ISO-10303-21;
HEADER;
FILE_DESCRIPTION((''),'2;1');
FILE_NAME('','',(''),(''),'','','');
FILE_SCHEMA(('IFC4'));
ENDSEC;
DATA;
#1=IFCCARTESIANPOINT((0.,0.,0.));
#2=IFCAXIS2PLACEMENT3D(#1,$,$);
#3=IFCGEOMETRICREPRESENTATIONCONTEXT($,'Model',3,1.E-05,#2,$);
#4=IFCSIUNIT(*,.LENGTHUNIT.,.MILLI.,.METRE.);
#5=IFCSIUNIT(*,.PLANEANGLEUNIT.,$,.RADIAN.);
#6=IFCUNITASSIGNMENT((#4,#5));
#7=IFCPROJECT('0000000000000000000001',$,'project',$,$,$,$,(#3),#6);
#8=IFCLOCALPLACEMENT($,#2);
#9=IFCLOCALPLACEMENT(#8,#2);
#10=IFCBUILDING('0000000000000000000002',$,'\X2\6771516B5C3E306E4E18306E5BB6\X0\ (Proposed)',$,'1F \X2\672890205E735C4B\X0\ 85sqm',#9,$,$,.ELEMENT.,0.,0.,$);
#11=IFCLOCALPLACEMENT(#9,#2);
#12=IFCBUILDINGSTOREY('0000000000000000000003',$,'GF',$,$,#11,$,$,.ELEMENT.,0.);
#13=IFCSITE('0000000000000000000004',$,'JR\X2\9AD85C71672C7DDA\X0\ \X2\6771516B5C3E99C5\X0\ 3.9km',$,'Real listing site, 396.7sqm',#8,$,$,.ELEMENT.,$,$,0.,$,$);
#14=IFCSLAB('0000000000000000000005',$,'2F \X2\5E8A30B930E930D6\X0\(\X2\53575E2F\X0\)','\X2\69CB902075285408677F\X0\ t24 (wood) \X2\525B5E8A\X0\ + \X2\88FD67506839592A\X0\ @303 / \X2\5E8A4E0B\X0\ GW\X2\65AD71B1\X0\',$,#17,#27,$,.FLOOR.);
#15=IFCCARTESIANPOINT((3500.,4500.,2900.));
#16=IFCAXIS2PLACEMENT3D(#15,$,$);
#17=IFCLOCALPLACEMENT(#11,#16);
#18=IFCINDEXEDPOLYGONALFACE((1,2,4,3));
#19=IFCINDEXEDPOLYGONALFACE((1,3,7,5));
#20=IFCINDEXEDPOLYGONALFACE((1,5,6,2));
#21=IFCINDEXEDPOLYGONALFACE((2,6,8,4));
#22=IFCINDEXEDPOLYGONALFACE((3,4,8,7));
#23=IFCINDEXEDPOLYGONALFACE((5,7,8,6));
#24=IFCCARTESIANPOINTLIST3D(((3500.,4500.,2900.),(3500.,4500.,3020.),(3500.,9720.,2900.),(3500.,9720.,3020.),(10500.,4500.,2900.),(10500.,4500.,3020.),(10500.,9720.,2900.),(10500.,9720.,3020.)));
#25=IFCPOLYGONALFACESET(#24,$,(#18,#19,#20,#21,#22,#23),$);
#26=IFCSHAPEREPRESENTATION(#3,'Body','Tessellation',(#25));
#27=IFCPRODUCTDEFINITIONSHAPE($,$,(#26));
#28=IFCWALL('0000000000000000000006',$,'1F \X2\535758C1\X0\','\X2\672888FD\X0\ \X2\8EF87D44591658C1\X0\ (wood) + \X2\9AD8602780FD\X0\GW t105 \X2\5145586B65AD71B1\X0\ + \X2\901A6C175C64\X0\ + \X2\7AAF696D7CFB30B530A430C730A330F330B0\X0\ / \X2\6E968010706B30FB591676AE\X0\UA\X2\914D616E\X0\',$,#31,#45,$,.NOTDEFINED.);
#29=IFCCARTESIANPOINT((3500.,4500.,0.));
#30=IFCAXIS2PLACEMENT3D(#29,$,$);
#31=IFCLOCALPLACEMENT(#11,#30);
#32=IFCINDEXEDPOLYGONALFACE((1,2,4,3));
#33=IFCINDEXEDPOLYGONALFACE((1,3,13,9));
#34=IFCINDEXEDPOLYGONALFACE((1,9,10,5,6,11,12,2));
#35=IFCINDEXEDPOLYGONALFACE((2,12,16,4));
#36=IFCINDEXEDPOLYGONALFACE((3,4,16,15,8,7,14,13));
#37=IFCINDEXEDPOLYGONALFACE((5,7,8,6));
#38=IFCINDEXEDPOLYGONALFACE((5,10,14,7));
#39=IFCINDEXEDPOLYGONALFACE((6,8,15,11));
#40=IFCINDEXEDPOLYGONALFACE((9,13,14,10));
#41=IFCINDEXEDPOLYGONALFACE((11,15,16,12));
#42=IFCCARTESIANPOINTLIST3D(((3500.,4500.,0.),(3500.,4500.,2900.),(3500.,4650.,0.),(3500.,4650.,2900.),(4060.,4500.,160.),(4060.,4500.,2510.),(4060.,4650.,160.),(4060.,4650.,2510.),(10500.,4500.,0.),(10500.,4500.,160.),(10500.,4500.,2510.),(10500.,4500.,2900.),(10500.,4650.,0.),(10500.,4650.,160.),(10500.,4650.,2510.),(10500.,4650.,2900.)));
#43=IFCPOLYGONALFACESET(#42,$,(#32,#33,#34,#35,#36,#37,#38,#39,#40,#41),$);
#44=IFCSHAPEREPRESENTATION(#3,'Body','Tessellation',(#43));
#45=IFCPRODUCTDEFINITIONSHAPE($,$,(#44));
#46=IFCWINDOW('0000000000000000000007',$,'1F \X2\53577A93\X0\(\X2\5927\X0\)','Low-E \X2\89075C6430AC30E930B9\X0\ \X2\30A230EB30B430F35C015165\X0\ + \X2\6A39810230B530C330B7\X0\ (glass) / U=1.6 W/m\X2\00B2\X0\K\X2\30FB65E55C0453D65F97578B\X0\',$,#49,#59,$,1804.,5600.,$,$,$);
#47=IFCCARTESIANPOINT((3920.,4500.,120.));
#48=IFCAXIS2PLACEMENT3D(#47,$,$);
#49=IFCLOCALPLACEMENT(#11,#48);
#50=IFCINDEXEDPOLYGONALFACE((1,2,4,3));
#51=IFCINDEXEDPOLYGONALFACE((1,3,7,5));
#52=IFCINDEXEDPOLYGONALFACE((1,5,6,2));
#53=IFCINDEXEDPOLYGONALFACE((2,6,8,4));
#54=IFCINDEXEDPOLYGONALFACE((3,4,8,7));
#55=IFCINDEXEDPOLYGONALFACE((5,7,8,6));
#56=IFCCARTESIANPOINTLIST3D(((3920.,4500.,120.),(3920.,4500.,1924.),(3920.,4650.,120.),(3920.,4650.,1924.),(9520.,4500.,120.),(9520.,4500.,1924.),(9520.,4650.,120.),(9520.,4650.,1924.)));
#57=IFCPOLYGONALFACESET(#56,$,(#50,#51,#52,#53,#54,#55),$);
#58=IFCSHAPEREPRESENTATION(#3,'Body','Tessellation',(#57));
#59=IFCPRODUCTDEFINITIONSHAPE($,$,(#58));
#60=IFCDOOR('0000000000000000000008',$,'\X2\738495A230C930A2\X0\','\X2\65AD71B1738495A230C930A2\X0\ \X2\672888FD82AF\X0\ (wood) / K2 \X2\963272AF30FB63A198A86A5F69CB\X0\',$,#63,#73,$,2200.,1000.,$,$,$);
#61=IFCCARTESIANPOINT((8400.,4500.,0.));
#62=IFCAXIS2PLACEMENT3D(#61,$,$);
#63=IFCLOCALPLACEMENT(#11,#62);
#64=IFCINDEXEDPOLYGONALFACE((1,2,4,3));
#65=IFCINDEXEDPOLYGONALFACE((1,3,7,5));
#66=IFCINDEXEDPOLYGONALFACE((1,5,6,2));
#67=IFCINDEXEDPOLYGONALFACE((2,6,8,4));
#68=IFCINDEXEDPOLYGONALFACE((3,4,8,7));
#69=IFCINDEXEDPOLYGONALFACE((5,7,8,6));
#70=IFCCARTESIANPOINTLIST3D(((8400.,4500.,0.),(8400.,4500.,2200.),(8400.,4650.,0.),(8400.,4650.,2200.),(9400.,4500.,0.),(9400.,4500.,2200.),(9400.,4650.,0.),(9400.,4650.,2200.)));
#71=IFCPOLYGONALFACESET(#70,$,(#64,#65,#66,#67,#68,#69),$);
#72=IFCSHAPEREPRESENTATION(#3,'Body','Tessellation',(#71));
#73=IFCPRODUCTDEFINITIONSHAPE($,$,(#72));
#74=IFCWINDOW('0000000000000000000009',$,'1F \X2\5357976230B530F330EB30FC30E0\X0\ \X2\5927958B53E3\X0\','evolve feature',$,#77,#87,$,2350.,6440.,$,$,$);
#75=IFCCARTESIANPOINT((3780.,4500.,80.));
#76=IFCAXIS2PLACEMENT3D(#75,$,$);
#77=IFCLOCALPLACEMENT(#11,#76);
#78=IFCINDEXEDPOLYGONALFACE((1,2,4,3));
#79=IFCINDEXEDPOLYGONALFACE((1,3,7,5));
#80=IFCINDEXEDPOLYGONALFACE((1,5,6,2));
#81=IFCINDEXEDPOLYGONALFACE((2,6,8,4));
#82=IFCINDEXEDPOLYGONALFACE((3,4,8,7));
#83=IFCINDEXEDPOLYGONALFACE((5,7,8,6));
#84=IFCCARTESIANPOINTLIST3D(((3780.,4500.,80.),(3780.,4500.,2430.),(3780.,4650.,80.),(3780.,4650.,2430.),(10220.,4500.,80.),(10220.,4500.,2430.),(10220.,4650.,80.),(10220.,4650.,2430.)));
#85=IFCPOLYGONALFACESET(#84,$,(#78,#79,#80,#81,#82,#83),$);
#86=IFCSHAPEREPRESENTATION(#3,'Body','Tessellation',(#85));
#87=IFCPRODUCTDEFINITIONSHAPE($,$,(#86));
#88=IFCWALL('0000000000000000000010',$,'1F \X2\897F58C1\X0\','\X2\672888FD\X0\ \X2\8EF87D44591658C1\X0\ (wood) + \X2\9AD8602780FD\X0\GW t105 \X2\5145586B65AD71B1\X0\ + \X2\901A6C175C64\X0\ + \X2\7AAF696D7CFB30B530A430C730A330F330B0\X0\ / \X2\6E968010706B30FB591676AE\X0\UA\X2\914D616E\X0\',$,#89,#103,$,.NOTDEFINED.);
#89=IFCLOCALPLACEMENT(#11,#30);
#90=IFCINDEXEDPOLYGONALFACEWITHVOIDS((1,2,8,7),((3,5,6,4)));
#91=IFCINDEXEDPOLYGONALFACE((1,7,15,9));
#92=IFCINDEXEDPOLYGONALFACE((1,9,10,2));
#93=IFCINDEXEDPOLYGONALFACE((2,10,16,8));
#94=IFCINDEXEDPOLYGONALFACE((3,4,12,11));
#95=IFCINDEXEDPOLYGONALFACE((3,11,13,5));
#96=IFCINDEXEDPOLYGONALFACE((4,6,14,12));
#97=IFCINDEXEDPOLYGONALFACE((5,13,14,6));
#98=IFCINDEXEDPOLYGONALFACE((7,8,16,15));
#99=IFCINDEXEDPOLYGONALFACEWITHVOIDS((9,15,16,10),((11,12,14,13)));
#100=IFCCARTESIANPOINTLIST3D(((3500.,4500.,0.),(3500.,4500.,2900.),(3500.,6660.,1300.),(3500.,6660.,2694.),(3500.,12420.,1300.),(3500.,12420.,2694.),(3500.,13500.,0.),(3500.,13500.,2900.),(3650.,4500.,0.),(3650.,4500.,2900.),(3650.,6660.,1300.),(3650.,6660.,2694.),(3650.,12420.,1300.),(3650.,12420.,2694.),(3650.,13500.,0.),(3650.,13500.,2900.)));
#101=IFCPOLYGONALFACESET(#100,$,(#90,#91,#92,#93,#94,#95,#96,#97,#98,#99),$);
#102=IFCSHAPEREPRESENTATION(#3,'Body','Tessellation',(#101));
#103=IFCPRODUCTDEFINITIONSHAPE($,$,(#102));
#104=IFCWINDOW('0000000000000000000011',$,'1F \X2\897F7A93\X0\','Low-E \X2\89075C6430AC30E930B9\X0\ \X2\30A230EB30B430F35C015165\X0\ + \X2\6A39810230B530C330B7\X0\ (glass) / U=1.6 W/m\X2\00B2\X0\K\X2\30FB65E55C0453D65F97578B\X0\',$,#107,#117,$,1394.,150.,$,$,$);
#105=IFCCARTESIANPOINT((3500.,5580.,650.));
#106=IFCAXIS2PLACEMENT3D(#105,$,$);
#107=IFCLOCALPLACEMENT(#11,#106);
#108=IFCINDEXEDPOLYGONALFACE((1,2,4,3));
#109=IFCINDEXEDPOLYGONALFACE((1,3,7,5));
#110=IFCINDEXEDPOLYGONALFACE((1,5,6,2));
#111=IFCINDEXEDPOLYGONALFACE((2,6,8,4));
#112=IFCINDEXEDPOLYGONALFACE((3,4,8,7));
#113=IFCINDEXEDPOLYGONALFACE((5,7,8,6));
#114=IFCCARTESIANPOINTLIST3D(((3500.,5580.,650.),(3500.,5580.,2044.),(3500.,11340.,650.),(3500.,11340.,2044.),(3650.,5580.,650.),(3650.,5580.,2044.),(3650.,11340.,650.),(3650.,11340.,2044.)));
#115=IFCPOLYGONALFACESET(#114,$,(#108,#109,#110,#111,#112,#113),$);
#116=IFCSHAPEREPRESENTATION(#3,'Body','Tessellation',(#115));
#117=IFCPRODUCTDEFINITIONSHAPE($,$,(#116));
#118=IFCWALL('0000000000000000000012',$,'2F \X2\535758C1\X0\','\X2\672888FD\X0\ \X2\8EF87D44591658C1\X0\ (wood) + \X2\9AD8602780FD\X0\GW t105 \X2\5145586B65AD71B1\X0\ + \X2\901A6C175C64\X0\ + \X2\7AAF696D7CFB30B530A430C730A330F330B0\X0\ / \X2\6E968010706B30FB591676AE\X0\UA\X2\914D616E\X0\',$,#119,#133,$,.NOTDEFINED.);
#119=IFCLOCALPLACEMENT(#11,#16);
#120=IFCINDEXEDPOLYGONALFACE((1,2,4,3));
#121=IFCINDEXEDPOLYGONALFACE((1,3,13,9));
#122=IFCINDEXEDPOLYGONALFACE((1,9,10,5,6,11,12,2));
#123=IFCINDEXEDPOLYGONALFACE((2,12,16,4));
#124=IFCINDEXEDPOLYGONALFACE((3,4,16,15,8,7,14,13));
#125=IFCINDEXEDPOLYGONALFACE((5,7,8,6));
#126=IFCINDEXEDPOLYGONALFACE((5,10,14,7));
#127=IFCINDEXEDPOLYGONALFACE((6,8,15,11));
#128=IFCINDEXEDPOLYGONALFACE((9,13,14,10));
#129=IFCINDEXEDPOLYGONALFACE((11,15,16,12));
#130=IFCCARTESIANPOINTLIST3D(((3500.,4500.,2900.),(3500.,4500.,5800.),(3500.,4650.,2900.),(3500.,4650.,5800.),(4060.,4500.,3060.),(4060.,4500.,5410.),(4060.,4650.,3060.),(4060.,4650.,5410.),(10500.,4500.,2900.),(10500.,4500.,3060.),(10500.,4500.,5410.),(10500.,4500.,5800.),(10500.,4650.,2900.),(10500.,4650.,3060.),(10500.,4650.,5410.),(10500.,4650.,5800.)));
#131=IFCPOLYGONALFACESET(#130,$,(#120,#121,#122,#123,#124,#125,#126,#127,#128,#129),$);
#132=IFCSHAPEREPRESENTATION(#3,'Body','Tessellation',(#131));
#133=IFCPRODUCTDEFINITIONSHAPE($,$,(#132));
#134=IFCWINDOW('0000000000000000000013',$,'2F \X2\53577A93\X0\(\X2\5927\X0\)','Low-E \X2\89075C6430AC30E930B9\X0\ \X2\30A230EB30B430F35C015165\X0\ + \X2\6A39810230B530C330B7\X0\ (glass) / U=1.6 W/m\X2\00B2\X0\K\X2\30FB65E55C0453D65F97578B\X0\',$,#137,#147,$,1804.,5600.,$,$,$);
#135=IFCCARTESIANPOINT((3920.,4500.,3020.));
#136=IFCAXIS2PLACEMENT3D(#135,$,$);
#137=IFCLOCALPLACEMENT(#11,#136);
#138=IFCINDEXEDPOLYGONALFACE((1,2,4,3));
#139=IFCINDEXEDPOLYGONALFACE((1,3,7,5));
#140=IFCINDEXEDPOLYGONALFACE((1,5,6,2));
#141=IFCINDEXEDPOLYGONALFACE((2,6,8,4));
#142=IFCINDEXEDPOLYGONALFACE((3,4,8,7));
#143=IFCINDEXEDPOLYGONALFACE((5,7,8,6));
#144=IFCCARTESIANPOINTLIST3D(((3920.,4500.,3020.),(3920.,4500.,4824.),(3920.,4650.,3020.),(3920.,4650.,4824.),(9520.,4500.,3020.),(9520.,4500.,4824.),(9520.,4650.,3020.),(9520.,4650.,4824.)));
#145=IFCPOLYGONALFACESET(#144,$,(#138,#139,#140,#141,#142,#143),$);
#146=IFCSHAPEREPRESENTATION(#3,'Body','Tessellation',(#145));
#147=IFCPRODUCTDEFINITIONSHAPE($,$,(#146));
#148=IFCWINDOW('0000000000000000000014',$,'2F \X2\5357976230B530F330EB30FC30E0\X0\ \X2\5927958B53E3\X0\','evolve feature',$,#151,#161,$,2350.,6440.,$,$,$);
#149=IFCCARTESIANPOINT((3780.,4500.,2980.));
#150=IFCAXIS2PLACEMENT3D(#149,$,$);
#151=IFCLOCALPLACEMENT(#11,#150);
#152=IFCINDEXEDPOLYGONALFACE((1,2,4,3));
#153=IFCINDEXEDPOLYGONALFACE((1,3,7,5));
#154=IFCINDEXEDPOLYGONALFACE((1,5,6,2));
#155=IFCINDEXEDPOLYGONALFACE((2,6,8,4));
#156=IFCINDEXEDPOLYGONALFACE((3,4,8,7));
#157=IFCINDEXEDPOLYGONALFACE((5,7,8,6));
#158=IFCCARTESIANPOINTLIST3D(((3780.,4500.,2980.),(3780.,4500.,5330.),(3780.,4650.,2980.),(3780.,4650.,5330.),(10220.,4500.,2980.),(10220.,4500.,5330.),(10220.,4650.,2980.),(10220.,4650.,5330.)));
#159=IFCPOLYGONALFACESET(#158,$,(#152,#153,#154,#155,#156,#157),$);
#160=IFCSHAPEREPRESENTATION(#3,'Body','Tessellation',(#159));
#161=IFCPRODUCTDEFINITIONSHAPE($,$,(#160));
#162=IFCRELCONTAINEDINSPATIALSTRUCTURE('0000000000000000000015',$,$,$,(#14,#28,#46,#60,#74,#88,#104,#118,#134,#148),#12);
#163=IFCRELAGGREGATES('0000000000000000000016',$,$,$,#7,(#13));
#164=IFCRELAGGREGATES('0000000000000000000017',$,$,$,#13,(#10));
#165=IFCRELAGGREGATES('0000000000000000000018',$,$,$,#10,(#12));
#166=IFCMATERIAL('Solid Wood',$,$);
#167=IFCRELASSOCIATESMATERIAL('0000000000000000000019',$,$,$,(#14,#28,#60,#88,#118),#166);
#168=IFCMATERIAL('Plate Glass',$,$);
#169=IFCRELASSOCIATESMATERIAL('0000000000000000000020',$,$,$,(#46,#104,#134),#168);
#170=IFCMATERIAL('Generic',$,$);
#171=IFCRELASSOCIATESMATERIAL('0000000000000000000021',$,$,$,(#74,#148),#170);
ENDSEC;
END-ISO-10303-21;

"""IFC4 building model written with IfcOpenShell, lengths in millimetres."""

from ifc_helpers import new_model, si_unit, frame, frame_2d, origin, place, context, project, spatial, rectangle, extrude, material, element, fill, save


model = new_model("IFC4")

# Units and contexts
model_context = context("Model", 3, precision=1e-05, world=origin())
ifc_project = project(units=[si_unit("LENGTHUNIT", "METRE", prefix="MILLI"), si_unit("PLANEANGLEUNIT", "RADIAN")], contexts=[model_context])

# Site, building, storey
site_placement = place(None, origin())
site = spatial("IfcSite", under=ifc_project, at=site_placement, Name="JR高山本線 東八尾駅 3.9km", ObjectType="Real listing site, 396.7sqm", CompositionType="ELEMENT", RefElevation=0.0)
building_placement = place(site_placement, origin())
building = spatial("IfcBuilding", under=site, at=building_placement, Name="東八尾の丘の家 (Proposed)", ObjectType="1F 木造平屋 85sqm", CompositionType="ELEMENT", ElevationOfRefHeight=0.0, ElevationOfTerrain=0.0)
storey_placement = place(building_placement, origin())
storey = spatial("IfcBuildingStorey", under=building, at=storey_placement, Name="GF", CompositionType="ELEMENT", Elevation=0.0)

# Slab
ifc_material_1 = material(Name="Solid Wood")
slab_1_placement = place(storey_placement, frame((3500.0, 4500.0, 2900.0)))
element("IfcSlab", 1, at=slab_1_placement, inside=storey, material=ifc_material_1, Name="2F 床スラブ(南帯)", Description="構造用合板 t24 (wood) 剛床 + 製材根太 @303 / 床下 GW断熱", PredefinedType="FLOOR", context=model_context, shape_type="SweptSolid", body=[
    extrude(rectangle(XDim=7000.0, YDim=5220.0, at=frame_2d((3500.0, 2610.0))), frame((3500.0, 4500.0, 2900.0)), (0.0, 0.0, 1.0), 120.0),
])
ifc_material_2 = material(Name="Generic")

# Wall, openings, windows, door
wall_1_placement = place(storey_placement, frame((3500.0, 4500.0, 0.0)))
wall_1 = element("IfcWall", 2, at=wall_1_placement, inside=storey, material=ifc_material_1, Name="1F 南壁", Description="木製 軸組外壁 (wood) + 高性能GW t105 充填断熱 + 通気層 + 窯業系サイディング / 準耐火・外皮UA配慮", PredefinedType="NOTDEFINED", context=model_context, shape_type="SweptSolid", body=[
    extrude(rectangle(XDim=7000.0, YDim=150.0, at=frame_2d((3500.0, 75.0))), frame((3500.0, 4500.0, 0.0)), (0.0, 0.0, 1.0), 2900.0),
])
opening_1_placement = place(storey_placement, frame((3920.0, 4500.0, 120.0)))
opening_1 = element("IfcOpeningElement", 3, at=opening_1_placement, cuts=wall_1, PredefinedType="NOTDEFINED", context=model_context, shape_type="SweptSolid", body=[
    extrude(rectangle(XDim=5600.0, YDim=150.0, at=frame_2d((2800.0, 75.0))), frame((3920.0, 4500.0, 120.0)), (0.0, 0.0, 1.0), 1804.0),
])
opening_2_placement = place(storey_placement, frame((8400.0, 4500.0, 0.0)))
opening_2 = element("IfcOpeningElement", 4, at=opening_2_placement, cuts=wall_1, PredefinedType="NOTDEFINED", context=model_context, shape_type="SweptSolid", body=[
    extrude(rectangle(XDim=1000.0, YDim=150.0, at=frame_2d((500.0, 75.0))), frame((8400.0, 4500.0, 0.0)), (0.0, 0.0, 1.0), 2200.0),
])
opening_3_placement = place(storey_placement, frame((3780.0, 4500.0, 80.0)))
opening_3 = element("IfcOpeningElement", 5, at=opening_3_placement, cuts=wall_1, PredefinedType="NOTDEFINED", context=model_context, shape_type="SweptSolid", body=[
    extrude(rectangle(XDim=6440.0, YDim=150.0, at=frame_2d((3220.0, 75.0))), frame((3780.0, 4500.0, 80.0)), (0.0, 0.0, 1.0), 2350.0),
])
ifc_material_3 = material(Name="Plate Glass")
window_1_placement = place(storey_placement, frame((3920.0, 4500.0, 120.0)))
window_1 = element("IfcWindow", 6, at=window_1_placement, inside=storey, material=ifc_material_3, Name="1F 南窓(大)", Description="Low-E 複層ガラス アルゴン封入 + 樹脂サッシ (glass) / U=1.6 W/m²K・日射取得型", OverallHeight=1804.0, OverallWidth=5600.0, context=model_context, shape_type="SweptSolid", body=[
    extrude(rectangle(XDim=5600.0, YDim=150.0, at=frame_2d((2800.0, 75.0))), frame((3920.0, 4500.0, 120.0)), (0.0, 0.0, 1.0), 1804.0),
])
fill(opening_1, window_1)
door_placement = place(storey_placement, frame((8400.0, 4500.0, 0.0)))
door = element("IfcDoor", 7, at=door_placement, inside=storey, material=ifc_material_1, Name="玄関ドア", Description="断熱玄関ドア 木製芯 (wood) / K2 防犯・採風機構", OverallHeight=2200.0, OverallWidth=1000.0, context=model_context, shape_type="SweptSolid", body=[
    extrude(rectangle(XDim=1000.0, YDim=150.0, at=frame_2d((500.0, 75.0))), frame((8400.0, 4500.0, 0.0)), (0.0, 0.0, 1.0), 2200.0),
])
fill(opening_2, door)
window_2_placement = place(storey_placement, frame((3780.0, 4500.0, 80.0)))
window_2 = element("IfcWindow", 8, at=window_2_placement, inside=storey, material=ifc_material_2, Name="1F 南面サンルーム 大開口", Description="evolve feature", OverallHeight=2350.0, OverallWidth=6440.0, context=model_context, shape_type="SweptSolid", body=[
    extrude(rectangle(XDim=6440.0, YDim=150.0, at=frame_2d((3220.0, 75.0))), frame((3780.0, 4500.0, 80.0)), (0.0, 0.0, 1.0), 2350.0),
])
fill(opening_3, window_2)

# Wall, opening, window
wall_2_placement = place(storey_placement, frame((3500.0, 4500.0, 0.0)))
wall_2 = element("IfcWall", 9, at=wall_2_placement, inside=storey, material=ifc_material_1, Name="1F 西壁", Description="木製 軸組外壁 (wood) + 高性能GW t105 充填断熱 + 通気層 + 窯業系サイディング / 準耐火・外皮UA配慮", PredefinedType="NOTDEFINED", context=model_context, shape_type="SweptSolid", body=[
    extrude(rectangle(XDim=150.0, YDim=9000.0, at=frame_2d((75.0, 4500.0))), frame((3500.0, 4500.0, 0.0)), (0.0, 0.0, 1.0), 2900.0),
])
opening_4_placement = place(storey_placement, frame((3500.0, 5580.0, 650.0)))
opening_4 = element("IfcOpeningElement", 10, at=opening_4_placement, cuts=wall_2, PredefinedType="NOTDEFINED", context=model_context, shape_type="SweptSolid", body=[
    extrude(rectangle(XDim=150.0, YDim=5760.0, at=frame_2d((75.0, 2880.0))), frame((3500.0, 5580.0, 650.0)), (0.0, 0.0, 1.0), 1394.0),
])
window_3_placement = place(storey_placement, frame((3500.0, 5580.0, 650.0)))
window_3 = element("IfcWindow", 11, at=window_3_placement, inside=storey, material=ifc_material_3, Name="1F 西窓", Description="Low-E 複層ガラス アルゴン封入 + 樹脂サッシ (glass) / U=1.6 W/m²K・日射取得型", OverallHeight=1394.0, OverallWidth=150.0, context=model_context, shape_type="SweptSolid", body=[
    extrude(rectangle(XDim=150.0, YDim=5760.0, at=frame_2d((75.0, 2880.0))), frame((3500.0, 5580.0, 650.0)), (0.0, 0.0, 1.0), 1394.0),
])
fill(opening_4, window_3)

# Wall, openings, windows
wall_3_placement = place(storey_placement, frame((3500.0, 4500.0, 2900.0)))
wall_3 = element("IfcWall", 12, at=wall_3_placement, inside=storey, material=ifc_material_1, Name="2F 南壁", Description="木製 軸組外壁 (wood) + 高性能GW t105 充填断熱 + 通気層 + 窯業系サイディング / 準耐火・外皮UA配慮", PredefinedType="NOTDEFINED", context=model_context, shape_type="SweptSolid", body=[
    extrude(rectangle(XDim=7000.0, YDim=150.0, at=frame_2d((3500.0, 75.0))), frame((3500.0, 4500.0, 2900.0)), (0.0, 0.0, 1.0), 2900.0),
])
opening_5_placement = place(storey_placement, frame((3920.0, 4500.0, 3020.0)))
opening_5 = element("IfcOpeningElement", 13, at=opening_5_placement, cuts=wall_3, PredefinedType="NOTDEFINED", context=model_context, shape_type="SweptSolid", body=[
    extrude(rectangle(XDim=5600.0, YDim=150.0, at=frame_2d((2800.0, 75.0))), frame((3920.0, 4500.0, 3020.0)), (0.0, 0.0, 1.0), 1804.0),
])
opening_6_placement = place(storey_placement, frame((3780.0, 4500.0, 2980.0)))
opening_6 = element("IfcOpeningElement", 14, at=opening_6_placement, cuts=wall_3, PredefinedType="NOTDEFINED", context=model_context, shape_type="SweptSolid", body=[
    extrude(rectangle(XDim=6440.0, YDim=150.0, at=frame_2d((3220.0, 75.0))), frame((3780.0, 4500.0, 2980.0)), (0.0, 0.0, 1.0), 2350.0),
])
window_4_placement = place(storey_placement, frame((3920.0, 4500.0, 3020.0)))
window_4 = element("IfcWindow", 15, at=window_4_placement, inside=storey, material=ifc_material_3, Name="2F 南窓(大)", Description="Low-E 複層ガラス アルゴン封入 + 樹脂サッシ (glass) / U=1.6 W/m²K・日射取得型", OverallHeight=1804.0, OverallWidth=5600.0, context=model_context, shape_type="SweptSolid", body=[
    extrude(rectangle(XDim=5600.0, YDim=150.0, at=frame_2d((2800.0, 75.0))), frame((3920.0, 4500.0, 3020.0)), (0.0, 0.0, 1.0), 1804.0),
])
fill(opening_5, window_4)
window_5_placement = place(storey_placement, frame((3780.0, 4500.0, 2980.0)))
window_5 = element("IfcWindow", 16, at=window_5_placement, inside=storey, material=ifc_material_2, Name="2F 南面サンルーム 大開口", Description="evolve feature", OverallHeight=2350.0, OverallWidth=6440.0, context=model_context, shape_type="SweptSolid", body=[
    extrude(rectangle(XDim=6440.0, YDim=150.0, at=frame_2d((3220.0, 75.0))), frame((3780.0, 4500.0, 2980.0)), (0.0, 0.0, 1.0), 2350.0),
])
fill(opening_6, window_5)

save(model, "model.ifc")
